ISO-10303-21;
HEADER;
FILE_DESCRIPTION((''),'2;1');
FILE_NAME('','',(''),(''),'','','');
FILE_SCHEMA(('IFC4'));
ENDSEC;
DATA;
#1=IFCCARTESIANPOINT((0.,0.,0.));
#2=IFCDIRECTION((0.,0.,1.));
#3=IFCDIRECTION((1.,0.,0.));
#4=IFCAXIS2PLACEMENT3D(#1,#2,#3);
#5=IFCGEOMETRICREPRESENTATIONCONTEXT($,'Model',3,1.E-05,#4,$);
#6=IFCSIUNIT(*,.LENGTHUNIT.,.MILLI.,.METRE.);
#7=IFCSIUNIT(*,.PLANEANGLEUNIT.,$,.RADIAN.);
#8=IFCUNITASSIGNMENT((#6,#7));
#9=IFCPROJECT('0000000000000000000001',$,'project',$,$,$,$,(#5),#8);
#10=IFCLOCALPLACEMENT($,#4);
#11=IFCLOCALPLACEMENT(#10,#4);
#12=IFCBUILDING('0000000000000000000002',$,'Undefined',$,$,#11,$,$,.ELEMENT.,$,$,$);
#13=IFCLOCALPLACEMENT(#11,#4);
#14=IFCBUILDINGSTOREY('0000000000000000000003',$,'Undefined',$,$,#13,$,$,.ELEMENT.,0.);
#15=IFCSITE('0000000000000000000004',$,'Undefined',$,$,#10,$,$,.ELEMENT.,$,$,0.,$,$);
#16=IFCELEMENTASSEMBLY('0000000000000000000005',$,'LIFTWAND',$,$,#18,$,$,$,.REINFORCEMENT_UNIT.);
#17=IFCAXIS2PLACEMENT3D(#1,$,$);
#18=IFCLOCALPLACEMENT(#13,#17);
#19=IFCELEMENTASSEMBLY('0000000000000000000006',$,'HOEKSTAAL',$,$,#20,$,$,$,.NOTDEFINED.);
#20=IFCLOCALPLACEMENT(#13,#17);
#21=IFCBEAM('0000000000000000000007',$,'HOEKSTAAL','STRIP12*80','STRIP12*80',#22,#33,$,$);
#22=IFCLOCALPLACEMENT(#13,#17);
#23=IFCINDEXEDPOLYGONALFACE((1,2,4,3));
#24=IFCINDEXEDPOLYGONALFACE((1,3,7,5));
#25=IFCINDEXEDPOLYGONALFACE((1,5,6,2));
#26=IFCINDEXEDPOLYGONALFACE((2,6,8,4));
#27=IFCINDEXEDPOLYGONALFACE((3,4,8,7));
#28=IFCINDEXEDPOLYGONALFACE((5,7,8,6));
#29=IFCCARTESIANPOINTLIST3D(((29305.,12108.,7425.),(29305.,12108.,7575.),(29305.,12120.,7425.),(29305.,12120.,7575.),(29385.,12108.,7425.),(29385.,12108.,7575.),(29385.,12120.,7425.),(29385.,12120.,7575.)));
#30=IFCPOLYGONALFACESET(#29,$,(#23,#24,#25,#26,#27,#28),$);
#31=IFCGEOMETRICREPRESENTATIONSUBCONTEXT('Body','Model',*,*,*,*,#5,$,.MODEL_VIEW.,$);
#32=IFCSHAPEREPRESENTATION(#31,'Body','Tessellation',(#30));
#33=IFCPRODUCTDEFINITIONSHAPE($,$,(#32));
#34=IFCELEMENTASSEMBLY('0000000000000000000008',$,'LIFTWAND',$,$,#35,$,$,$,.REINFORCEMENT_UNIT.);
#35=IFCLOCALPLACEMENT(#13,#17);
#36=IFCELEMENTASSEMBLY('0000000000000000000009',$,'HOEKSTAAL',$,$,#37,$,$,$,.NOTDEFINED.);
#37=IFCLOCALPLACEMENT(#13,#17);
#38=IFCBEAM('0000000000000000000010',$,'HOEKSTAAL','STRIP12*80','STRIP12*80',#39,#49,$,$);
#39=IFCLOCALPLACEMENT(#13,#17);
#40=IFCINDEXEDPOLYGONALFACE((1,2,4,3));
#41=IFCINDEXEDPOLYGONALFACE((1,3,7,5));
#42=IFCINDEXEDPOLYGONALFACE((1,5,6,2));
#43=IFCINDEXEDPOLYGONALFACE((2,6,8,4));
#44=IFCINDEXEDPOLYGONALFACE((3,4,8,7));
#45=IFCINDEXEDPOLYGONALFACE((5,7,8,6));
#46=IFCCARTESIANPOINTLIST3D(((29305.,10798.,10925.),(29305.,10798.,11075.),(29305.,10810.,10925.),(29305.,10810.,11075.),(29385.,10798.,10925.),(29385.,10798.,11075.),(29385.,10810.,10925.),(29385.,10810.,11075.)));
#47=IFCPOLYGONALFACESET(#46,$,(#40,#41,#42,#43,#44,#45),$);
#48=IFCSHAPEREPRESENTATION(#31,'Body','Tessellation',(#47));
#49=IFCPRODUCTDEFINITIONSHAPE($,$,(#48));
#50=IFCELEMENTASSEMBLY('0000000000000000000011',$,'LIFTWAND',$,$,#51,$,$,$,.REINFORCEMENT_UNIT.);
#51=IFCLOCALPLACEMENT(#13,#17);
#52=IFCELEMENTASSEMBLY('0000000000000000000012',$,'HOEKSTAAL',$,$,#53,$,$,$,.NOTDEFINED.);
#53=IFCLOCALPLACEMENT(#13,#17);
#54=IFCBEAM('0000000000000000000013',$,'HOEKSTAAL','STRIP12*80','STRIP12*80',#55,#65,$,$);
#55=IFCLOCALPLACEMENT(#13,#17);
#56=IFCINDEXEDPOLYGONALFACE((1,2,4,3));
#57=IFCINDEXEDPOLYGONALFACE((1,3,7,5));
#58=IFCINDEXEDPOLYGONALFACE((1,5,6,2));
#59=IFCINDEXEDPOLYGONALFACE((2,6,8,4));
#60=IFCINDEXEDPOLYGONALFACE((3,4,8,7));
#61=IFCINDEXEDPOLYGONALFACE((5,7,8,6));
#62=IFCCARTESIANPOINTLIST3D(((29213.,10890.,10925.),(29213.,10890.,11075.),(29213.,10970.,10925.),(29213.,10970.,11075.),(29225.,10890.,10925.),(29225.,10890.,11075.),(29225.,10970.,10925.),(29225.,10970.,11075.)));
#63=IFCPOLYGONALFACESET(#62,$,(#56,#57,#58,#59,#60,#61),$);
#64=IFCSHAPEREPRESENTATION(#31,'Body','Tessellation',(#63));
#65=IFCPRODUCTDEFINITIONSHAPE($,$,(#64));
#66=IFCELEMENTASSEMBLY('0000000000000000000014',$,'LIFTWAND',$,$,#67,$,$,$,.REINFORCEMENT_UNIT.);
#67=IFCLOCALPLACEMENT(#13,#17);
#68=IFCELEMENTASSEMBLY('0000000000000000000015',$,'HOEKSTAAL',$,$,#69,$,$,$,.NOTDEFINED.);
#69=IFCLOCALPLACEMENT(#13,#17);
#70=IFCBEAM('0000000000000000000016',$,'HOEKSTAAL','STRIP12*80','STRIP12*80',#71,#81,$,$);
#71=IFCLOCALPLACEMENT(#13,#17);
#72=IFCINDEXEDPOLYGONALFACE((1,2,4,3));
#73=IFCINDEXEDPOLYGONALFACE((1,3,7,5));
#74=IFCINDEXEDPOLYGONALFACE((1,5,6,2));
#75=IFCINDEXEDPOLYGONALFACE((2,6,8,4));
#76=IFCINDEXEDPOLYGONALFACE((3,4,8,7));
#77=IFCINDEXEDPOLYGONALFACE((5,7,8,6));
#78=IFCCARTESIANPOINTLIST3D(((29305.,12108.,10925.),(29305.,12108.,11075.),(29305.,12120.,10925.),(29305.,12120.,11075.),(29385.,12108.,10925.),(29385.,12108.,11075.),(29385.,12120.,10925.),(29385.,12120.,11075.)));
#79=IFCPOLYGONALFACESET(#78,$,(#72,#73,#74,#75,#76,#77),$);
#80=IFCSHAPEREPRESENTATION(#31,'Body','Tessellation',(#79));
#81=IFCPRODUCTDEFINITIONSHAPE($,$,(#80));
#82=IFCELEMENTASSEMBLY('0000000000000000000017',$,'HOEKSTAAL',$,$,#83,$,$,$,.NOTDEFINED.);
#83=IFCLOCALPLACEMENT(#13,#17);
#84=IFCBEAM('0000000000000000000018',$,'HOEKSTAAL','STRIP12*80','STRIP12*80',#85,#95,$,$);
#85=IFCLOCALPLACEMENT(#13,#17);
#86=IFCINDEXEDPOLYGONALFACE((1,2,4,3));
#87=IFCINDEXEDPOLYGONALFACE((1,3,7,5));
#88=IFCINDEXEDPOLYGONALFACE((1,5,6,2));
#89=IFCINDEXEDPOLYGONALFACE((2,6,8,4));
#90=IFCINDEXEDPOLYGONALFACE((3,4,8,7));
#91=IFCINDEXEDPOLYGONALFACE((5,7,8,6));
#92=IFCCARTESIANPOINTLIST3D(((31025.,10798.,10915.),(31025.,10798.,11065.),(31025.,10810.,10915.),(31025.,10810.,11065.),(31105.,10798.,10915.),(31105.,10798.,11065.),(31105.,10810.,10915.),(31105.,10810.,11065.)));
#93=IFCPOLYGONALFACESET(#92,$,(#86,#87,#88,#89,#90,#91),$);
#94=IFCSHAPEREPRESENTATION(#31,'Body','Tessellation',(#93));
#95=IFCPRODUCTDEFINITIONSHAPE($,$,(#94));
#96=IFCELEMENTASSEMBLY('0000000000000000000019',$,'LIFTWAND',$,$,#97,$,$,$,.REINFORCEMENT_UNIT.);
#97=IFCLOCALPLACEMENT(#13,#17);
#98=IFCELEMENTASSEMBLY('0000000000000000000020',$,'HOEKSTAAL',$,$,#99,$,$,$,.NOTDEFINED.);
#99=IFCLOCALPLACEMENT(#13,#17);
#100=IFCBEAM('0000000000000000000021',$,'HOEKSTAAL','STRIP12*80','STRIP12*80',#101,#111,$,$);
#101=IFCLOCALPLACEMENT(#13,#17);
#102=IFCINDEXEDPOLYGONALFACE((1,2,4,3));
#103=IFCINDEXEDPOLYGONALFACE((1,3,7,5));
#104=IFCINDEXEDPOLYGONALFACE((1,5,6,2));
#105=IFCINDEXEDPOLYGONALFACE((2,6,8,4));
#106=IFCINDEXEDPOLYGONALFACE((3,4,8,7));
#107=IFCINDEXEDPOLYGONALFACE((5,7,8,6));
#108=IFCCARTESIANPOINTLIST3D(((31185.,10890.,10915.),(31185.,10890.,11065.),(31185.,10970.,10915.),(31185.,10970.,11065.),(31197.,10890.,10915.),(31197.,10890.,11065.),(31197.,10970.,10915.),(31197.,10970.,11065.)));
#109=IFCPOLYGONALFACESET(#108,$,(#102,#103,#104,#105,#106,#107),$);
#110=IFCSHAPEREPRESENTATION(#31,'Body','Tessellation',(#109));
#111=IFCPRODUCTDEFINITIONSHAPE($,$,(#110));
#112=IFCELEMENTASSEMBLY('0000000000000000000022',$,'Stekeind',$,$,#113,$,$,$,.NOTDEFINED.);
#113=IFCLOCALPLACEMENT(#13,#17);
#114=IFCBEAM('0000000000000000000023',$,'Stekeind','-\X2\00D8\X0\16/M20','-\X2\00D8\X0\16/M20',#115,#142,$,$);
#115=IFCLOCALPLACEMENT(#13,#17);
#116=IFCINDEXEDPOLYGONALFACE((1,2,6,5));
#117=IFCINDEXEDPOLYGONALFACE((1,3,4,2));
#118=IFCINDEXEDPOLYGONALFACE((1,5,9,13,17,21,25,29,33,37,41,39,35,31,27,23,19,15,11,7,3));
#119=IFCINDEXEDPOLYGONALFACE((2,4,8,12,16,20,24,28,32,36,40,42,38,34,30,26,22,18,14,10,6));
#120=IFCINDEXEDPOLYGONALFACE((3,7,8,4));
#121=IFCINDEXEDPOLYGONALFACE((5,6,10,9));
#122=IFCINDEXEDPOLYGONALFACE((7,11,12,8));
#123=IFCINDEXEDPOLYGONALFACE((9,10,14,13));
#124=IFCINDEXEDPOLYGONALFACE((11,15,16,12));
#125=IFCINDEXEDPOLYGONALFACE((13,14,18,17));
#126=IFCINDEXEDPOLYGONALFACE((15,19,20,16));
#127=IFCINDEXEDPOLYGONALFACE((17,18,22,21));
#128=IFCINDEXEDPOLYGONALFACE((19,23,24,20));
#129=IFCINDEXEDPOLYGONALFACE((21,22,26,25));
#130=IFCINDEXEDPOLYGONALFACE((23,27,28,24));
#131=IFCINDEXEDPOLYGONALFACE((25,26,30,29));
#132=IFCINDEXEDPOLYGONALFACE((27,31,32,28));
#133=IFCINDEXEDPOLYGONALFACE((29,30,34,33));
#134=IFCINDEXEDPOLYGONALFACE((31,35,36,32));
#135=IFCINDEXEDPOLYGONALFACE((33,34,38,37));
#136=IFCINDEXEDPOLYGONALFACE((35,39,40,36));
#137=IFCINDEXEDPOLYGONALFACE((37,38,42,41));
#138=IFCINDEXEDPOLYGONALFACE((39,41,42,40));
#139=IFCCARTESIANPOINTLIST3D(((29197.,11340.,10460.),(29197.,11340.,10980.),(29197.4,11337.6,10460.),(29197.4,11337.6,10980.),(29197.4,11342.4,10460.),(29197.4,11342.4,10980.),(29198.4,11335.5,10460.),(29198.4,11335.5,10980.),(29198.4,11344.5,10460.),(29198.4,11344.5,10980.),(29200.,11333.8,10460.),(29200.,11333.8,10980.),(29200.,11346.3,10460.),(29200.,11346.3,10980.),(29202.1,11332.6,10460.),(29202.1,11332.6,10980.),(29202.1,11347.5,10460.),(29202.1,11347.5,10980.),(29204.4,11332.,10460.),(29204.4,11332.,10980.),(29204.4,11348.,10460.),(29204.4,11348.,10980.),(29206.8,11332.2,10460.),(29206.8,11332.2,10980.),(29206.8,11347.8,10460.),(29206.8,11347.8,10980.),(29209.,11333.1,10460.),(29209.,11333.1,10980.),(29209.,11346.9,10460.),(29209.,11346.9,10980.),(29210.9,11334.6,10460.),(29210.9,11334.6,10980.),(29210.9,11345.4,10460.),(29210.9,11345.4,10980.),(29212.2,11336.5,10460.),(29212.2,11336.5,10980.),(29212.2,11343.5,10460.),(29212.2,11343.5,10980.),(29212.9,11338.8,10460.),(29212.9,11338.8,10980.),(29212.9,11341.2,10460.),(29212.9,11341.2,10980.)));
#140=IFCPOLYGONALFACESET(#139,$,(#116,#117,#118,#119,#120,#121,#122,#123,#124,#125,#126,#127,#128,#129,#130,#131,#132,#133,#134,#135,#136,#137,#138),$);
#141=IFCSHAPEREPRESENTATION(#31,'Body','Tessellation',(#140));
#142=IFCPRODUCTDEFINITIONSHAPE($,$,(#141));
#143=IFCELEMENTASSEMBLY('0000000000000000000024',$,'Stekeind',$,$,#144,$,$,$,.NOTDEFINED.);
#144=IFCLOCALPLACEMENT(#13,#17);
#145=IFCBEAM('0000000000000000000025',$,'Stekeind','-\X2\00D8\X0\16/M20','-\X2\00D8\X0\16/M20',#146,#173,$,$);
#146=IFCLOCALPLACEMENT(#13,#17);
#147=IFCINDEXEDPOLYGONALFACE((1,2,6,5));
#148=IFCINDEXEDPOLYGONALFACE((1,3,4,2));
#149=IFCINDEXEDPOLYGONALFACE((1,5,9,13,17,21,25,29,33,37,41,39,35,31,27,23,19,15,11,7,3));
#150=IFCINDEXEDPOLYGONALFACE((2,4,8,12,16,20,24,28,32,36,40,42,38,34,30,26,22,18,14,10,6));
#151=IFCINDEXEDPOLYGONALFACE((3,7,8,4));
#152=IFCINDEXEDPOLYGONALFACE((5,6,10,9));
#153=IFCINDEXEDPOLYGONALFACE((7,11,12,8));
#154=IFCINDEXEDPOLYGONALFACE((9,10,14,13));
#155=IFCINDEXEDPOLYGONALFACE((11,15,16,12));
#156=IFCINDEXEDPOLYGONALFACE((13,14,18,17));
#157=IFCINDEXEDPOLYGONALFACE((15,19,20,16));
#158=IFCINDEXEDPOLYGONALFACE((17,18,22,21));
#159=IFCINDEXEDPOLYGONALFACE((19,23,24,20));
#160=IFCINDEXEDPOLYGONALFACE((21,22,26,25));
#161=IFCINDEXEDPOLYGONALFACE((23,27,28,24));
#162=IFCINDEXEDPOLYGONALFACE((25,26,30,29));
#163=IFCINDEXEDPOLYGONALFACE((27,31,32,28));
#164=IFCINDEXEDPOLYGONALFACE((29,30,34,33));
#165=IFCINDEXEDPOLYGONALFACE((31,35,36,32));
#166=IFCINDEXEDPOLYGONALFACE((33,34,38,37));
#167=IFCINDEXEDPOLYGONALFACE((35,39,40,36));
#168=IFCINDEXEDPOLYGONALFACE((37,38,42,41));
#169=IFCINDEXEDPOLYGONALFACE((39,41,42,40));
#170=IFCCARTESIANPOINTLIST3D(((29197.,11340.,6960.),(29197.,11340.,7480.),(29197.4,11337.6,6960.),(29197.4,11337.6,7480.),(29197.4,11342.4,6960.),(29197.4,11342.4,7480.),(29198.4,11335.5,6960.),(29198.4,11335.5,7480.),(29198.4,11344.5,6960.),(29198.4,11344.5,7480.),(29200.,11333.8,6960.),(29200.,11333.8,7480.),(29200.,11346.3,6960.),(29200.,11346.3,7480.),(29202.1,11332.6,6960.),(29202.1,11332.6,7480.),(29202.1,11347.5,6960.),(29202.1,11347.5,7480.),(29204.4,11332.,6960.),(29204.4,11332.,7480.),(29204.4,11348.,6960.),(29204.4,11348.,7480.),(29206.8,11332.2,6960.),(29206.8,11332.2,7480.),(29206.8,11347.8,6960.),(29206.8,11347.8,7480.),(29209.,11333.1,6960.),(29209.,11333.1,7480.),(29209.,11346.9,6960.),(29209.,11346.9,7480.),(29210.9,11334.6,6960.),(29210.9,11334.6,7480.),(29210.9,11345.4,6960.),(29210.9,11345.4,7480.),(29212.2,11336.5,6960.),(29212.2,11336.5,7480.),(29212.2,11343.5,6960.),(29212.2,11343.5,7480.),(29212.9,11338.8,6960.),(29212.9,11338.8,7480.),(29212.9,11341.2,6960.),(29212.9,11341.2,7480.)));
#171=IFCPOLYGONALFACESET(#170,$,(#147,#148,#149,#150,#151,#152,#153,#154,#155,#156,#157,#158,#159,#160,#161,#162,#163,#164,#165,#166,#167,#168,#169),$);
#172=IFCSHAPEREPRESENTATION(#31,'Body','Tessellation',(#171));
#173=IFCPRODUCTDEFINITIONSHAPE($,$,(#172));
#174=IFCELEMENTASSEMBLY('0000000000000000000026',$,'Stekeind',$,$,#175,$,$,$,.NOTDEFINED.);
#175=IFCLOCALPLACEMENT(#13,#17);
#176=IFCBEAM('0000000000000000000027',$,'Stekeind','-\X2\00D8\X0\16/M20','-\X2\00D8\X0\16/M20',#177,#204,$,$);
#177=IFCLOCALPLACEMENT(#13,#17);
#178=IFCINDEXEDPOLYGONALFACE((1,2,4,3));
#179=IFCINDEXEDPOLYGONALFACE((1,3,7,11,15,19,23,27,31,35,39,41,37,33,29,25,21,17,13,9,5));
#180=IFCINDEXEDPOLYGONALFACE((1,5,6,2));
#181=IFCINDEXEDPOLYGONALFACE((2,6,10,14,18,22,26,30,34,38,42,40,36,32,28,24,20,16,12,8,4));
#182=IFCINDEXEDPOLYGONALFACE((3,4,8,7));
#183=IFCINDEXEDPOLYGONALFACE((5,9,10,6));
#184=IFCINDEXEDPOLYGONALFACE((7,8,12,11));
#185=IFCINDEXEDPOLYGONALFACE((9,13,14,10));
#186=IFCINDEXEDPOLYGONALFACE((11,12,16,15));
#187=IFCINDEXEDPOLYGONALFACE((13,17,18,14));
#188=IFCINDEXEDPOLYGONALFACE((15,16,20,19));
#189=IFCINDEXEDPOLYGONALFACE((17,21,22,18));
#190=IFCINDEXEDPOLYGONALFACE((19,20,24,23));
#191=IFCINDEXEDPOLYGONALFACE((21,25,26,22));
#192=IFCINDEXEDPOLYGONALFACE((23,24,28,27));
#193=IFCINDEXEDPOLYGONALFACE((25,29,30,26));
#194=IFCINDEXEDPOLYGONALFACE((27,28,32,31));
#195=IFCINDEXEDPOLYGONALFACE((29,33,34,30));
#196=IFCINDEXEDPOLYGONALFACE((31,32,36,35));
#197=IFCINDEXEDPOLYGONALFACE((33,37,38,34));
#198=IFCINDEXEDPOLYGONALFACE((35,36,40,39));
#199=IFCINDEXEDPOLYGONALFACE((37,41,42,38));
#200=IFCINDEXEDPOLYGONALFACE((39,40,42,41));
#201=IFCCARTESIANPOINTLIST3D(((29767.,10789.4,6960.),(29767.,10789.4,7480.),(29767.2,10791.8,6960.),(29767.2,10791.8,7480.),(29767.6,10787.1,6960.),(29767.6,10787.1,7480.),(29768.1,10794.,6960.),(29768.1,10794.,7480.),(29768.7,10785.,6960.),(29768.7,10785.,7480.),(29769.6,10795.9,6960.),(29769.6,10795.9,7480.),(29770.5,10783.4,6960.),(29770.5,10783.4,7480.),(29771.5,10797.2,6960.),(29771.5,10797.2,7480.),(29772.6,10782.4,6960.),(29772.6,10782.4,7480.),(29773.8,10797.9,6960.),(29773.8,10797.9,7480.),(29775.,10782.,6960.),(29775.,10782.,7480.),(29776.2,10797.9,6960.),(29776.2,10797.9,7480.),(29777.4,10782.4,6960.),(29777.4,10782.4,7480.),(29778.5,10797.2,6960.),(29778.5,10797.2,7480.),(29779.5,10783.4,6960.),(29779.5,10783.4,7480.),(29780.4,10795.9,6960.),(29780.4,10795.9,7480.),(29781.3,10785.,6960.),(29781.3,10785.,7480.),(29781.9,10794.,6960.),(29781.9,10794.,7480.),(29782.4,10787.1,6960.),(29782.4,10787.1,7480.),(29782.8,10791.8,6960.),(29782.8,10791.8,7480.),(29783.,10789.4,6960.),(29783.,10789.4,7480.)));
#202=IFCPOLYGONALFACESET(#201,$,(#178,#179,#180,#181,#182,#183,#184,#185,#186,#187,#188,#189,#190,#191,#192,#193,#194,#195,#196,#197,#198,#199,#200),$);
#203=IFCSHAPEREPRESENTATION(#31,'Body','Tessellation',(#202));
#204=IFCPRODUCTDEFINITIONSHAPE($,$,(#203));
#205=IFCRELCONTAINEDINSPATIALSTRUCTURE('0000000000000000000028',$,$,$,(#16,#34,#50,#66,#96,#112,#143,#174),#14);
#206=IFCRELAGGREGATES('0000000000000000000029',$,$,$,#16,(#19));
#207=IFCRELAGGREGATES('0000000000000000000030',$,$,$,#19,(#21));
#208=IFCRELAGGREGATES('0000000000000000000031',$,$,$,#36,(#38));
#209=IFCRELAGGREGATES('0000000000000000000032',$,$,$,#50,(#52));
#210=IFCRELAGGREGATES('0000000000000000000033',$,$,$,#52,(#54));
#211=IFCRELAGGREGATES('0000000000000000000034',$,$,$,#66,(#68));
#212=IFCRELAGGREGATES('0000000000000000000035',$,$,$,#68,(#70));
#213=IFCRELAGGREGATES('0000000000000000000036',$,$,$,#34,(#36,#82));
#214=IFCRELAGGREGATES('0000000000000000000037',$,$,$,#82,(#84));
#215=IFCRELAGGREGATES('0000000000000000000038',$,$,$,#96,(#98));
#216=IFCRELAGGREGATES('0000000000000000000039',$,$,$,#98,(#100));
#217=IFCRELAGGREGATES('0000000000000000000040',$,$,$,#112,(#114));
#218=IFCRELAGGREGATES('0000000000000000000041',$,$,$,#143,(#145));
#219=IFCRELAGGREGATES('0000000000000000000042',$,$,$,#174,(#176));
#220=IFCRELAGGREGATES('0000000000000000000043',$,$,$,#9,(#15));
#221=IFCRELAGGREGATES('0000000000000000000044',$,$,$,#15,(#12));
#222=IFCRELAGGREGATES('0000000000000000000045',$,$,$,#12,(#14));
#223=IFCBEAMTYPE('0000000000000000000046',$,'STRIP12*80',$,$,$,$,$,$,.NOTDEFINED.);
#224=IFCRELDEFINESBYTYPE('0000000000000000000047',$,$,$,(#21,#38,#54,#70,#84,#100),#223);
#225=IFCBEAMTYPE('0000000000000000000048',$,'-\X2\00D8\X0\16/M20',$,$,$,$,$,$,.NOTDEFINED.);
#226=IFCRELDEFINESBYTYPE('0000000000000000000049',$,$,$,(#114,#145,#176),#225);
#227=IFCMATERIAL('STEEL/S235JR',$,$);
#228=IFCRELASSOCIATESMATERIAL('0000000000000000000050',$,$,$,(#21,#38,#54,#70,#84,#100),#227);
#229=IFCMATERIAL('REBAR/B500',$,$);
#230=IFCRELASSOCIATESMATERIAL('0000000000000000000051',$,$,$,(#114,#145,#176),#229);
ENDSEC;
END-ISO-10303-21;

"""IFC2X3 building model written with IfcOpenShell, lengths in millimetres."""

from ifc_helpers import new_model, si_unit, frame, origin_with_axes, origin_2d_with_axis, place, context, subcontext, project, spatial, rectangle, circle, extrude, material, type_object, element, aggregate, save


model = new_model("IFC2X3")

# Units and contexts
model_context = context("Model", 3, precision=1e-05, world=origin_with_axes())
body_context = subcontext(model_context, "Body", "Model", "MODEL_VIEW")
ifc_project = project(units=[si_unit("LENGTHUNIT", "METRE", prefix="MILLI"), si_unit("PLANEANGLEUNIT", "RADIAN")], contexts=[model_context])

# Site, building, storey
site_placement = place(None, origin_with_axes())
site = spatial("IfcSite", under=ifc_project, at=site_placement, Name="Undefined", CompositionType="ELEMENT", RefElevation=0.0)
building_placement = place(site_placement, origin_with_axes())
building = spatial("IfcBuilding", under=site, at=building_placement, Name="Undefined", CompositionType="ELEMENT")
storey_placement = place(building_placement, origin_with_axes())
storey = spatial("IfcBuildingStorey", under=building, at=storey_placement, Name="Undefined", CompositionType="ELEMENT", Elevation=0.0)

# Shared definitions
ifc_material_1 = material(Name="STEEL/S235JR")

# Shared definitions
beam_type_1 = type_object("IfcBeamType", Name="STRIP12*80", PredefinedType="NOTDEFINED")

# Element assemblies, beam
assembly_1_placement = place(storey_placement, origin_with_axes())
assembly_1 = element("IfcElementAssembly", 1, at=assembly_1_placement, inside=storey, Name="LIFTWAND", PredefinedType="REINFORCEMENT_UNIT")
assembly_2_placement = place(assembly_1_placement, origin_with_axes())
assembly_2 = element("IfcElementAssembly", 2, at=assembly_2_placement, Name="HOEKSTAAL", PredefinedType="NOTDEFINED")
aggregate(assembly_1, [assembly_2])
beam_1_placement = place(assembly_2_placement, frame((29345.0, 12114.0, 7575.0), z_axis=(1.0, 0.0, 0.0), x_axis=(0.0, 0.0, -1.0)))
beam_1 = element("IfcBeam", 3, at=beam_1_placement, type_object=beam_type_1, material=ifc_material_1, Name="HOEKSTAAL", Description="STRIP12*80", ObjectType="STRIP12*80", context=body_context, shape_type="SweptSolid", body=[
    extrude(rectangle(XDim=12.0, YDim=80.0, at=origin_2d_with_axis()), frame((150.0, 0.0, 0.0), z_axis=(-1.0, 0.0, 0.0), x_axis=(0.0, -1.0, 0.0)), (0.0, 0.0, 1.0), 150.0),
])
aggregate(assembly_2, [beam_1])

# Element assemblies, beams
assembly_3_placement = place(storey_placement, origin_with_axes())
assembly_3 = element("IfcElementAssembly", 4, at=assembly_3_placement, inside=storey, Name="LIFTWAND", PredefinedType="REINFORCEMENT_UNIT")
assembly_4_placement = place(assembly_3_placement, origin_with_axes())
assembly_4 = element("IfcElementAssembly", 5, at=assembly_4_placement, Name="HOEKSTAAL", PredefinedType="NOTDEFINED")
beam_2_placement = place(assembly_4_placement, frame((29345.0, 10804.0, 11075.0), z_axis=(1.0, 0.0, 0.0), x_axis=(0.0, 0.0, -1.0)))
beam_2 = element("IfcBeam", 6, at=beam_2_placement, type_object=beam_type_1, material=ifc_material_1, Name="HOEKSTAAL", Description="STRIP12*80", ObjectType="STRIP12*80", context=body_context, shape_type="SweptSolid", body=[
    extrude(rectangle(XDim=12.0, YDim=80.0, at=origin_2d_with_axis()), frame((150.0, 0.0, 0.0), z_axis=(-1.0, 0.0, 0.0), x_axis=(0.0, -1.0, 0.0)), (0.0, 0.0, 1.0), 150.0),
])
aggregate(assembly_4, [beam_2])
assembly_5_placement = place(storey_placement, origin_with_axes())
assembly_5 = element("IfcElementAssembly", 7, at=assembly_5_placement, inside=storey, Name="LIFTWAND", PredefinedType="REINFORCEMENT_UNIT")
assembly_6_placement = place(assembly_5_placement, origin_with_axes())
assembly_6 = element("IfcElementAssembly", 8, at=assembly_6_placement, Name="HOEKSTAAL", PredefinedType="NOTDEFINED")
aggregate(assembly_5, [assembly_6])
beam_3_placement = place(assembly_6_placement, frame((29219.0, 10930.0, 11075.0), z_axis=(0.0, -1.0, 0.0), x_axis=(0.0, 0.0, -1.0)))
beam_3 = element("IfcBeam", 9, at=beam_3_placement, type_object=beam_type_1, material=ifc_material_1, Name="HOEKSTAAL", Description="STRIP12*80", ObjectType="STRIP12*80", context=body_context, shape_type="SweptSolid", body=[
    extrude(rectangle(XDim=12.0, YDim=80.0, at=origin_2d_with_axis()), frame((150.0, 0.0, 0.0), z_axis=(-1.0, 0.0, 0.0), x_axis=(0.0, -1.0, 0.0)), (0.0, 0.0, 1.0), 150.0),
])
aggregate(assembly_6, [beam_3])
assembly_7_placement = place(storey_placement, origin_with_axes())
assembly_7 = element("IfcElementAssembly", 10, at=assembly_7_placement, inside=storey, Name="LIFTWAND", PredefinedType="REINFORCEMENT_UNIT")
assembly_8_placement = place(assembly_7_placement, origin_with_axes())
assembly_8 = element("IfcElementAssembly", 11, at=assembly_8_placement, Name="HOEKSTAAL", PredefinedType="NOTDEFINED")
aggregate(assembly_7, [assembly_8])
beam_4_placement = place(assembly_8_placement, frame((29345.0, 12114.0, 11075.0), z_axis=(1.0, 0.0, 0.0), x_axis=(0.0, 0.0, -1.0)))
beam_4 = element("IfcBeam", 12, at=beam_4_placement, type_object=beam_type_1, material=ifc_material_1, Name="HOEKSTAAL", Description="STRIP12*80", ObjectType="STRIP12*80", context=body_context, shape_type="SweptSolid", body=[
    extrude(rectangle(XDim=12.0, YDim=80.0, at=origin_2d_with_axis()), frame((150.0, 0.0, 0.0), z_axis=(-1.0, 0.0, 0.0), x_axis=(0.0, -1.0, 0.0)), (0.0, 0.0, 1.0), 150.0),
])
aggregate(assembly_8, [beam_4])

# Element assembly
assembly_9_placement = place(assembly_3_placement, origin_with_axes())
assembly_9 = element("IfcElementAssembly", 13, at=assembly_9_placement, Name="HOEKSTAAL", PredefinedType="NOTDEFINED")
aggregate(assembly_3, [assembly_4, assembly_9])

# Beam
beam_5_placement = place(assembly_9_placement, frame((31065.0, 10804.0, 11065.0), z_axis=(-1.0, 0.0, 0.0), x_axis=(0.0, 0.0, -1.0)))
beam_5 = element("IfcBeam", 14, at=beam_5_placement, type_object=beam_type_1, material=ifc_material_1, Name="HOEKSTAAL", Description="STRIP12*80", ObjectType="STRIP12*80", context=body_context, shape_type="SweptSolid", body=[
    extrude(rectangle(XDim=12.0, YDim=80.0, at=origin_2d_with_axis()), frame((150.0, 0.0, 0.0), z_axis=(-1.0, 0.0, 0.0), x_axis=(0.0, -1.0, 0.0)), (0.0, 0.0, 1.0), 150.0),
])
aggregate(assembly_9, [beam_5])

# Element assemblies, beam
assembly_10_placement = place(storey_placement, origin_with_axes())
assembly_10 = element("IfcElementAssembly", 15, at=assembly_10_placement, inside=storey, Name="LIFTWAND", PredefinedType="REINFORCEMENT_UNIT")
assembly_11_placement = place(assembly_10_placement, origin_with_axes())
assembly_11 = element("IfcElementAssembly", 16, at=assembly_11_placement, Name="HOEKSTAAL", PredefinedType="NOTDEFINED")
aggregate(assembly_10, [assembly_11])
beam_6_placement = place(assembly_11_placement, frame((31191.0, 10930.0, 11065.0), z_axis=(0.0, -1.0, 0.0), x_axis=(0.0, 0.0, -1.0)))
beam_6 = element("IfcBeam", 17, at=beam_6_placement, type_object=beam_type_1, material=ifc_material_1, Name="HOEKSTAAL", Description="STRIP12*80", ObjectType="STRIP12*80", context=body_context, shape_type="SweptSolid", body=[
    extrude(rectangle(XDim=12.0, YDim=80.0, at=origin_2d_with_axis()), frame((150.0, 0.0, 0.0), z_axis=(-1.0, 0.0, 0.0), x_axis=(0.0, -1.0, 0.0)), (0.0, 0.0, 1.0), 150.0),
])
aggregate(assembly_11, [beam_6])

# Element assemblies, beams
assembly_12_placement = place(storey_placement, origin_with_axes())
assembly_12 = element("IfcElementAssembly", 18, at=assembly_12_placement, inside=storey, Name="Stekeind", PredefinedType="NOTDEFINED")
ifc_material_2 = material(Name="REBAR/B500")
beam_type_2 = type_object("IfcBeamType", Name="-Ø16/M20", PredefinedType="NOTDEFINED")
beam_7_placement = place(assembly_12_placement, frame((29205.0, 11340.0, 10980.0), z_axis=(0.0, -1.0, 0.0), x_axis=(0.0, 0.0, -1.0)))
beam_7 = element("IfcBeam", 19, at=beam_7_placement, type_object=beam_type_2, material=ifc_material_2, Name="Stekeind", Description="-Ø16/M20", ObjectType="-Ø16/M20", context=body_context, shape_type="SweptSolid", body=[
    extrude(circle(Radius=8.0, at=origin_2d_with_axis()), frame((520.0, 0.0, 0.0), z_axis=(-1.0, 0.0, 0.0), x_axis=(0.0, -1.0, 0.0)), (0.0, 0.0, 1.0), 520.0),
])
aggregate(assembly_12, [beam_7])
assembly_13_placement = place(storey_placement, origin_with_axes())
assembly_13 = element("IfcElementAssembly", 20, at=assembly_13_placement, inside=storey, Name="Stekeind", PredefinedType="NOTDEFINED")
beam_8_placement = place(assembly_13_placement, frame((29205.0, 11340.0, 7480.0), z_axis=(0.0, -1.0, 0.0), x_axis=(0.0, 0.0, -1.0)))
beam_8 = element("IfcBeam", 21, at=beam_8_placement, type_object=beam_type_2, material=ifc_material_2, Name="Stekeind", Description="-Ø16/M20", ObjectType="-Ø16/M20", context=body_context, shape_type="SweptSolid", body=[
    extrude(circle(Radius=8.0, at=origin_2d_with_axis()), frame((520.0, 0.0, 0.0), z_axis=(-1.0, 0.0, 0.0), x_axis=(0.0, -1.0, 0.0)), (0.0, 0.0, 1.0), 520.0),
])
aggregate(assembly_13, [beam_8])
assembly_14_placement = place(storey_placement, origin_with_axes())
assembly_14 = element("IfcElementAssembly", 22, at=assembly_14_placement, inside=storey, Name="Stekeind", PredefinedType="NOTDEFINED")
beam_9_placement = place(assembly_14_placement, frame((29775.0, 10790.0, 7480.0), z_axis=(1.0, 0.0, 0.0), x_axis=(0.0, 0.0, -1.0)))
beam_9 = element("IfcBeam", 23, at=beam_9_placement, type_object=beam_type_2, material=ifc_material_2, Name="Stekeind", Description="-Ø16/M20", ObjectType="-Ø16/M20", context=body_context, shape_type="SweptSolid", body=[
    extrude(circle(Radius=8.0, at=origin_2d_with_axis()), frame((520.0, 0.0, 0.0), z_axis=(-1.0, 0.0, 0.0), x_axis=(0.0, -1.0, 0.0)), (0.0, 0.0, 1.0), 520.0),
])
aggregate(assembly_14, [beam_9])

save(model, "model.ifc")
